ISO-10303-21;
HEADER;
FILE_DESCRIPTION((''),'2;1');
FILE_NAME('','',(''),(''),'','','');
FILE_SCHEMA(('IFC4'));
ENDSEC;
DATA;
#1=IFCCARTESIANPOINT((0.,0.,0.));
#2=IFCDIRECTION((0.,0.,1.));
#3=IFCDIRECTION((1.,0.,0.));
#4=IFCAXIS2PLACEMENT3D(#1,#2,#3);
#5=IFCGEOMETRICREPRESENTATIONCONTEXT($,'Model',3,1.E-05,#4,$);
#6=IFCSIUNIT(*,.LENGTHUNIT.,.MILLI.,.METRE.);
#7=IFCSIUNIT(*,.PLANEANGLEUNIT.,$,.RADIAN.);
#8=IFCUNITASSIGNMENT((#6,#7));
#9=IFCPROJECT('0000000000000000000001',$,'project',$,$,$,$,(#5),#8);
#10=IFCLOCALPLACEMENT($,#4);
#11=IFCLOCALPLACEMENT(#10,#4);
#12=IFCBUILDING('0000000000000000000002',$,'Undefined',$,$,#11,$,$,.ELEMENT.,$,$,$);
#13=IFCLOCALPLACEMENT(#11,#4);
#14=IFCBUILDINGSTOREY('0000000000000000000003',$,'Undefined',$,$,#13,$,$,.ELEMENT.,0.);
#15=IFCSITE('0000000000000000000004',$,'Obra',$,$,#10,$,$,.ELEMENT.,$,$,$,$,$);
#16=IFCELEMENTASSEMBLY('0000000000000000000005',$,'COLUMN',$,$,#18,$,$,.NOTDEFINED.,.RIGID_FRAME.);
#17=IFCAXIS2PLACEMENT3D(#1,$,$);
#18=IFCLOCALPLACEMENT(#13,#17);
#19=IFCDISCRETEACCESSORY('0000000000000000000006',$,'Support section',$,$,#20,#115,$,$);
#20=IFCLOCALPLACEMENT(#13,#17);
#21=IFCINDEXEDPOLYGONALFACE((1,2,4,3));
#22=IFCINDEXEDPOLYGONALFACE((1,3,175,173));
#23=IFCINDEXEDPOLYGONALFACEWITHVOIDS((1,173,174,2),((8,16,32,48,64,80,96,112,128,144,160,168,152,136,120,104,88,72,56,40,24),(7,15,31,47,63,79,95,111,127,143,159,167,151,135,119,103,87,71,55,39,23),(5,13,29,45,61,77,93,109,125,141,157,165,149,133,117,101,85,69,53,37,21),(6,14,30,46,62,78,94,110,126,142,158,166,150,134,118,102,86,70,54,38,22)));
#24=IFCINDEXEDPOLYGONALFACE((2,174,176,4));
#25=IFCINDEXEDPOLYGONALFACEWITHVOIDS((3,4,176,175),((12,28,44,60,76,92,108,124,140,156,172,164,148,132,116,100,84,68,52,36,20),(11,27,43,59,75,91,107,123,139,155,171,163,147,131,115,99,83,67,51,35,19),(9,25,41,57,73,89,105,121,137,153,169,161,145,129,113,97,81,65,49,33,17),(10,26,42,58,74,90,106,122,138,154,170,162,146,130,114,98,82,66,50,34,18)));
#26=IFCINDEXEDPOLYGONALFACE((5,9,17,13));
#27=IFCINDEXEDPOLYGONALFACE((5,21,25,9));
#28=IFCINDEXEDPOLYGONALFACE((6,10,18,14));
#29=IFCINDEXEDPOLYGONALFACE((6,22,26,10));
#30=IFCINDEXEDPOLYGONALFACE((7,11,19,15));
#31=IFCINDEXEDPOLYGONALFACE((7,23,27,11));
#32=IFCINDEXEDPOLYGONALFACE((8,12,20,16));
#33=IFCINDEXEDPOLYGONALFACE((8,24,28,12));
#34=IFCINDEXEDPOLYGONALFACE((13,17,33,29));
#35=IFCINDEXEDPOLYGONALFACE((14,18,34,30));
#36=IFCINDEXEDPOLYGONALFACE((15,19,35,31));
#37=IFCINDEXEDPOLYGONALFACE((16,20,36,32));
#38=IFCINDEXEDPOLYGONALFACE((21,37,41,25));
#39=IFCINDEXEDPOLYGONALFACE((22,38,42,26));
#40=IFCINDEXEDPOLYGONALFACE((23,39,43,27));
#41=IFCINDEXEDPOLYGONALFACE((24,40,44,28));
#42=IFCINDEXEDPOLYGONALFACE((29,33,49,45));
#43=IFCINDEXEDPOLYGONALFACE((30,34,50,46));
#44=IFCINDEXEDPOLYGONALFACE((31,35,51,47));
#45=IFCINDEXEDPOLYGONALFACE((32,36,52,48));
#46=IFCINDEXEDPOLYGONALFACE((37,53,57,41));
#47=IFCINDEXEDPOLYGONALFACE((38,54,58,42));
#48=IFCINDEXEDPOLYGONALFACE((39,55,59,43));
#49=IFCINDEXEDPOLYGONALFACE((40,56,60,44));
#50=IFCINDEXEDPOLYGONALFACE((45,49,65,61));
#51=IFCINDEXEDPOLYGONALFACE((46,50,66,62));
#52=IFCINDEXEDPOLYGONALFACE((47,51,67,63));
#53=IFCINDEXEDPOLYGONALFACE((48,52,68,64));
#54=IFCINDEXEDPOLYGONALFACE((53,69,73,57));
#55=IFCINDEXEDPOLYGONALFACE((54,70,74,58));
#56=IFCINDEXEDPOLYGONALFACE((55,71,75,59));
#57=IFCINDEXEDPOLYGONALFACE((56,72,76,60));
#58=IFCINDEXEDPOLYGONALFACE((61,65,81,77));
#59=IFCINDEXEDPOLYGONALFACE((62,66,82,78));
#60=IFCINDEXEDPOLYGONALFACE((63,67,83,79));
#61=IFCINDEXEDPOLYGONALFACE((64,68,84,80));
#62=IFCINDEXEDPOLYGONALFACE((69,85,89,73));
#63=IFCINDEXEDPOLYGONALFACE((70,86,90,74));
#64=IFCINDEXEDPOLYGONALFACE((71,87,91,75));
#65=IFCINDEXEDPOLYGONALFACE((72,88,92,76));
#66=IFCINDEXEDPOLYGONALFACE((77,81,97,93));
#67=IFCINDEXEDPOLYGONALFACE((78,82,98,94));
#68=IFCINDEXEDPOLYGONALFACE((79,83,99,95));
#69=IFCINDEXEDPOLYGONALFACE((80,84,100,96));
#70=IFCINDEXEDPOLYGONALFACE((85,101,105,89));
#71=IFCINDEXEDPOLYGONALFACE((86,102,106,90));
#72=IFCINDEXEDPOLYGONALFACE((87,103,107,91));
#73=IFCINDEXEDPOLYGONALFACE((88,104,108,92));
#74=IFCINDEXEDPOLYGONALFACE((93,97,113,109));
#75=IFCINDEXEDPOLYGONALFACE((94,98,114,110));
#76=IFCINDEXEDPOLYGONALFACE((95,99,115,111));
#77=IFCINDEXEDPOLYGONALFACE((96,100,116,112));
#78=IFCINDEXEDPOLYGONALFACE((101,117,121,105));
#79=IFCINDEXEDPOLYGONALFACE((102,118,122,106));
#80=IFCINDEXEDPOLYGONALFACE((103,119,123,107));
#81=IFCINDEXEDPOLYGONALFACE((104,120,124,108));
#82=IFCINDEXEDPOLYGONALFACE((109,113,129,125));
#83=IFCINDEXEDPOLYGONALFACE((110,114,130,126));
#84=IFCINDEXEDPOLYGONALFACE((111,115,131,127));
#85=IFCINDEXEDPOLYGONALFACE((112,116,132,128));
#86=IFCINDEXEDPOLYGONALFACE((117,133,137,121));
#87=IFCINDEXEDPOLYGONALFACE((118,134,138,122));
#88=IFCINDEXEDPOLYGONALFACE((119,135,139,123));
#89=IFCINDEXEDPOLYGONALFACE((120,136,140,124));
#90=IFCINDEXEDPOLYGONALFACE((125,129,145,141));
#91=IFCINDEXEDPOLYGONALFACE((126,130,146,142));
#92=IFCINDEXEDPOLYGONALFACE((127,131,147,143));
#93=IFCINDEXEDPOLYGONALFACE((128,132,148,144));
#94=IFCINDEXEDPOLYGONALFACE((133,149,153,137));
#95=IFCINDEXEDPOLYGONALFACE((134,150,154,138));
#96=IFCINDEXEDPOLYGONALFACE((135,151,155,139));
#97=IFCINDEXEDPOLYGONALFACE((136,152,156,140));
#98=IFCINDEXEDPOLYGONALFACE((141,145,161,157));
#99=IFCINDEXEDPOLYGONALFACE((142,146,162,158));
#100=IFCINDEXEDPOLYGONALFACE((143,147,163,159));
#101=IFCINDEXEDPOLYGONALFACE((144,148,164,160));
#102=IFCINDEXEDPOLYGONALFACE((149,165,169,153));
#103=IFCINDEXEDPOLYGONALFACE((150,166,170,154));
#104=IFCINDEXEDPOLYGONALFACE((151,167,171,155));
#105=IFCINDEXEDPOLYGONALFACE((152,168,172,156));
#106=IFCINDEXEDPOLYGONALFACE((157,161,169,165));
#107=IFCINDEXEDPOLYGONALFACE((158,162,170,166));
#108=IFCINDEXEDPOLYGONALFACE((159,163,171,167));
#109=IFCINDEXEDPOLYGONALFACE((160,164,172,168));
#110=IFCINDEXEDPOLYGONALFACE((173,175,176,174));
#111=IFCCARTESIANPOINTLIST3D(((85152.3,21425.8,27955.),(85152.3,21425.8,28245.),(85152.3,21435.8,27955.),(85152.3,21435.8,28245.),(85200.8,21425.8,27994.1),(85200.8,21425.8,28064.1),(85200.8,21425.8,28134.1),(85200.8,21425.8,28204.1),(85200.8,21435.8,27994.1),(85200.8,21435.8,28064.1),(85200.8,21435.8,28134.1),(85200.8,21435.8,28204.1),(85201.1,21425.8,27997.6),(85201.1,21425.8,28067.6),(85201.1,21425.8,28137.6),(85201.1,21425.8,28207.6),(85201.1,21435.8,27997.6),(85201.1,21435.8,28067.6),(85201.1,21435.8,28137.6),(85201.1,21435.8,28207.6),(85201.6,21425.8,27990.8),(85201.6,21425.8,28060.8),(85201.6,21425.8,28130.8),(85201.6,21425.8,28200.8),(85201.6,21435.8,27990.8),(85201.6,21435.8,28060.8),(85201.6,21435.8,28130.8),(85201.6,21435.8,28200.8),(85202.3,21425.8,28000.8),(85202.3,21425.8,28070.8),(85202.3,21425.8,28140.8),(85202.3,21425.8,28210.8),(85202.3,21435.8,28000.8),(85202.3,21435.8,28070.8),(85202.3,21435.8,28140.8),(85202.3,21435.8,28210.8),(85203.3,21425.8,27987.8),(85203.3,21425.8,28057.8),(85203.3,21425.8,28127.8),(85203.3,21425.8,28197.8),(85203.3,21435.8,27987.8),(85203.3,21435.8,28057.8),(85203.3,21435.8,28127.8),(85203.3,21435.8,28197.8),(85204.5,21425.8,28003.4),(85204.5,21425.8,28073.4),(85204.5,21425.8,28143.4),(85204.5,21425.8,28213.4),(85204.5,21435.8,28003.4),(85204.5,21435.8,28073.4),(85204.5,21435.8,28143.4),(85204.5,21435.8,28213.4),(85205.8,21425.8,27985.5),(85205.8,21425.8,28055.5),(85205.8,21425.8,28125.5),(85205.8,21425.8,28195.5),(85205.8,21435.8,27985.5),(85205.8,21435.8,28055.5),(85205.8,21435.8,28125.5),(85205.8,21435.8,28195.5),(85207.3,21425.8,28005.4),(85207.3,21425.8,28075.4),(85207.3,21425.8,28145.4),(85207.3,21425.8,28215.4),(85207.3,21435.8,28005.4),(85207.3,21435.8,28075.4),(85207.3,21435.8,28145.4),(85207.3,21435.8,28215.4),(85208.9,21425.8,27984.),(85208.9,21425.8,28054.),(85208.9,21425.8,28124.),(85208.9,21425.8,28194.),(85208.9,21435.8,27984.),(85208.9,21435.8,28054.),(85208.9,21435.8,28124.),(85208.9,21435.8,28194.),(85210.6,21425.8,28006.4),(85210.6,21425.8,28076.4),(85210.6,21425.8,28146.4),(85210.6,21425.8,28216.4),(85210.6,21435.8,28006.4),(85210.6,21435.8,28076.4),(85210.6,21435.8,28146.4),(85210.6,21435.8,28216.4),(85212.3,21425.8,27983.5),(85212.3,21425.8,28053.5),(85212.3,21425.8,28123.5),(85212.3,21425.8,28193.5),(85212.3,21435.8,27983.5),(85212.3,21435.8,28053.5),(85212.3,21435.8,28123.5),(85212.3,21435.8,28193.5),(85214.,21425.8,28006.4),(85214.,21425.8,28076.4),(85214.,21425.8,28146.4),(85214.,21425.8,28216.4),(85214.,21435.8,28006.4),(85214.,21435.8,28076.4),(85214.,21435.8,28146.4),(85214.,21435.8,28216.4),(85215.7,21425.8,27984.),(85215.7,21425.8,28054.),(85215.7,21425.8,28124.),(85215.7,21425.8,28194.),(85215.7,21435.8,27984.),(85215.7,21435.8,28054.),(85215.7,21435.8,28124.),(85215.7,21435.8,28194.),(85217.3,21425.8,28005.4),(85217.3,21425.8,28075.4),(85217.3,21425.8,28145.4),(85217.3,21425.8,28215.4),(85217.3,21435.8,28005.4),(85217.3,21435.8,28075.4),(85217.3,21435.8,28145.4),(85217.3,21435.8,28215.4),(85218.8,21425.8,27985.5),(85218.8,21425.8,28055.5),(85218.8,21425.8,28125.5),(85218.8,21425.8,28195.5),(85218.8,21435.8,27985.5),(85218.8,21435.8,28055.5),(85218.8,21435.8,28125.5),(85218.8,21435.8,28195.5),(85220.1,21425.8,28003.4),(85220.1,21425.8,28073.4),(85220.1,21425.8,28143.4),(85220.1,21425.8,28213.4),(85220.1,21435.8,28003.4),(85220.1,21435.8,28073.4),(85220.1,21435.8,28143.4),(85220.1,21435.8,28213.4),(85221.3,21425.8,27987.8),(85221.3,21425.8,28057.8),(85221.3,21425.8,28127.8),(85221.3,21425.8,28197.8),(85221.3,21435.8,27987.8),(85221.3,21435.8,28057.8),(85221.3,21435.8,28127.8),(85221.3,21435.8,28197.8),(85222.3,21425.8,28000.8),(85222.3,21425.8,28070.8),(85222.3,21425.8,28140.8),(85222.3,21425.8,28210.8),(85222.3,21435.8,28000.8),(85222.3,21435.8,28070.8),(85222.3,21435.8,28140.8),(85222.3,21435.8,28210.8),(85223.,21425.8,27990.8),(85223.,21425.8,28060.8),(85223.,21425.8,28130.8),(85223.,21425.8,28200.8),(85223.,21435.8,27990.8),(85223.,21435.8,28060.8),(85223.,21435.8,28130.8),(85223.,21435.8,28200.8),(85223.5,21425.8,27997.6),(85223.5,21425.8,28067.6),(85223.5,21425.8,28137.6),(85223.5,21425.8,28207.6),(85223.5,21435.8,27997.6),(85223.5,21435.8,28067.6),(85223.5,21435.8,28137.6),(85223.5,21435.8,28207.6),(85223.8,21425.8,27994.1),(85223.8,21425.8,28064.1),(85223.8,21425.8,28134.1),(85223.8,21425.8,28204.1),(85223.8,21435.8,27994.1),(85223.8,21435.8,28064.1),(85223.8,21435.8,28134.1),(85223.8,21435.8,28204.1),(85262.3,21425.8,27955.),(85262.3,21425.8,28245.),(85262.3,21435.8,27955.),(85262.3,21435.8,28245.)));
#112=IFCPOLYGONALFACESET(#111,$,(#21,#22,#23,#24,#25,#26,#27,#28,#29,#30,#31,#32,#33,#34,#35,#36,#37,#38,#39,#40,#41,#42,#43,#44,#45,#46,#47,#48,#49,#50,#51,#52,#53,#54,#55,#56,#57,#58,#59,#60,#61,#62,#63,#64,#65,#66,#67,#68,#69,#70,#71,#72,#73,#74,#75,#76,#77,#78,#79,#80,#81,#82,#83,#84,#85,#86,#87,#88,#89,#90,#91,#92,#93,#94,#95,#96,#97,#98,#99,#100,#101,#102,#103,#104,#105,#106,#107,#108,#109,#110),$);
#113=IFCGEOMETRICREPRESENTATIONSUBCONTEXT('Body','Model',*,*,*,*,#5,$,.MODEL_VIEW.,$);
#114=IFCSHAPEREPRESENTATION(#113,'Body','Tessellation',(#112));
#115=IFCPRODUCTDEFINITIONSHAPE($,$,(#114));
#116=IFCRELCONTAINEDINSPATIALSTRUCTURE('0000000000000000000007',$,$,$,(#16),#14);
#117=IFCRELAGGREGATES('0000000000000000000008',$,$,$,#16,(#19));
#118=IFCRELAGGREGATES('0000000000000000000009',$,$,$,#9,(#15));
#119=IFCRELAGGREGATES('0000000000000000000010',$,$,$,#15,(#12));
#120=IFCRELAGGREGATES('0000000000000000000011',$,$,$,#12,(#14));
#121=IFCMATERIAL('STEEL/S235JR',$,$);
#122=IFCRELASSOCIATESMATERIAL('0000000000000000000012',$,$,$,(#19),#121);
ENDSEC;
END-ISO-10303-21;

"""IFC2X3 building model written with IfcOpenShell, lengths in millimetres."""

from ifc_helpers import new_model, si_unit, frame, origin_with_axes, origin_2d_with_axis, place, context, subcontext, project, spatial, rectangle, circle, extrude, source, transform, mapped, material, element, aggregate, save


model = new_model("IFC2X3")

# Units and contexts
model_context = context("Model", 3, precision=1e-05, world=origin_with_axes())
body_context = subcontext(model_context, "Body", "Model", "MODEL_VIEW")
ifc_project = project(units=[si_unit("LENGTHUNIT", "METRE", prefix="MILLI"), si_unit("PLANEANGLEUNIT", "RADIAN")], contexts=[model_context])

# Site, building, storey
site_placement = place(None, origin_with_axes())
site = spatial("IfcSite", under=ifc_project, at=site_placement, Name="Obra", CompositionType="ELEMENT")
building_placement = place(site_placement, origin_with_axes())
building = spatial("IfcBuilding", under=site, at=building_placement, Name="Undefined", CompositionType="ELEMENT")
storey_placement = place(building_placement, origin_with_axes())
storey = spatial("IfcBuildingStorey", under=building, at=storey_placement, Name="Undefined", CompositionType="ELEMENT", Elevation=0.0)

# Element assembly
ifc_material = material(Name="STEEL/S235JR")
assembly_1_placement = place(storey_placement, origin_with_axes())
assembly_1 = element("IfcElementAssembly", 1, at=assembly_1_placement, inside=storey, Name="COLUMN", AssemblyPlace="NOTDEFINED", PredefinedType="RIGID_FRAME")

# Discrete accessory, opening
discrete_accessory_1_placement = place(assembly_1_placement, frame((85207.3, 21430.8, 27955.0), z_axis=(0.0, 0.0, 1.0), x_axis=(-1.0, 0.0, 0.0)))
discrete_accessory_1 = element("IfcDiscreteAccessory", 2, at=discrete_accessory_1_placement, material=ifc_material, Name="Support section", context=body_context, shape_type="SweptSolid", body=[
    extrude(rectangle(XDim=10.0, YDim=110.0, at=origin_2d_with_axis()), frame((0.0, 0.0, 290.0), z_axis=(0.0, 0.0, -1.0), x_axis=(0.0, 1.0, 0.0)), (0.0, 0.0, 1.0), 290.0),
])
shared_shape_1 = source(origin_with_axes(), body_context, "Body", "SweptSolid", [
    extrude(circle(Radius=11.5, at=origin_2d_with_axis()), frame((0.0, -14.4, 0.0), z_axis=(0.0, 1.0, 0.0), x_axis=(1.0, 0.0, 0.0)), (0.0, 0.0, 1.0), 10.2),
])
opening_1_placement = place(assembly_1_placement, frame((85162.3, 21440.1, 28300.0), z_axis=(1.0, 0.0, 0.0), x_axis=(0.0, 0.0, -1.0)))
element("IfcOpeningElement", 3, at=opening_1_placement, cuts=discrete_accessory_1, ObjectType="Opening", context=body_context, shape_type="MappedRepresentation", body=[
    mapped(shared_shape_1, transform((95.0, 0.0, 50.0))),
    mapped(shared_shape_1, transform((165.0, 0.0, 50.0))),
    mapped(shared_shape_1, transform((235.0, 0.0, 50.0))),
    mapped(shared_shape_1, transform((305.0, 0.0, 50.0))),
])
aggregate(assembly_1, [discrete_accessory_1])

save(model, "model.ifc")
